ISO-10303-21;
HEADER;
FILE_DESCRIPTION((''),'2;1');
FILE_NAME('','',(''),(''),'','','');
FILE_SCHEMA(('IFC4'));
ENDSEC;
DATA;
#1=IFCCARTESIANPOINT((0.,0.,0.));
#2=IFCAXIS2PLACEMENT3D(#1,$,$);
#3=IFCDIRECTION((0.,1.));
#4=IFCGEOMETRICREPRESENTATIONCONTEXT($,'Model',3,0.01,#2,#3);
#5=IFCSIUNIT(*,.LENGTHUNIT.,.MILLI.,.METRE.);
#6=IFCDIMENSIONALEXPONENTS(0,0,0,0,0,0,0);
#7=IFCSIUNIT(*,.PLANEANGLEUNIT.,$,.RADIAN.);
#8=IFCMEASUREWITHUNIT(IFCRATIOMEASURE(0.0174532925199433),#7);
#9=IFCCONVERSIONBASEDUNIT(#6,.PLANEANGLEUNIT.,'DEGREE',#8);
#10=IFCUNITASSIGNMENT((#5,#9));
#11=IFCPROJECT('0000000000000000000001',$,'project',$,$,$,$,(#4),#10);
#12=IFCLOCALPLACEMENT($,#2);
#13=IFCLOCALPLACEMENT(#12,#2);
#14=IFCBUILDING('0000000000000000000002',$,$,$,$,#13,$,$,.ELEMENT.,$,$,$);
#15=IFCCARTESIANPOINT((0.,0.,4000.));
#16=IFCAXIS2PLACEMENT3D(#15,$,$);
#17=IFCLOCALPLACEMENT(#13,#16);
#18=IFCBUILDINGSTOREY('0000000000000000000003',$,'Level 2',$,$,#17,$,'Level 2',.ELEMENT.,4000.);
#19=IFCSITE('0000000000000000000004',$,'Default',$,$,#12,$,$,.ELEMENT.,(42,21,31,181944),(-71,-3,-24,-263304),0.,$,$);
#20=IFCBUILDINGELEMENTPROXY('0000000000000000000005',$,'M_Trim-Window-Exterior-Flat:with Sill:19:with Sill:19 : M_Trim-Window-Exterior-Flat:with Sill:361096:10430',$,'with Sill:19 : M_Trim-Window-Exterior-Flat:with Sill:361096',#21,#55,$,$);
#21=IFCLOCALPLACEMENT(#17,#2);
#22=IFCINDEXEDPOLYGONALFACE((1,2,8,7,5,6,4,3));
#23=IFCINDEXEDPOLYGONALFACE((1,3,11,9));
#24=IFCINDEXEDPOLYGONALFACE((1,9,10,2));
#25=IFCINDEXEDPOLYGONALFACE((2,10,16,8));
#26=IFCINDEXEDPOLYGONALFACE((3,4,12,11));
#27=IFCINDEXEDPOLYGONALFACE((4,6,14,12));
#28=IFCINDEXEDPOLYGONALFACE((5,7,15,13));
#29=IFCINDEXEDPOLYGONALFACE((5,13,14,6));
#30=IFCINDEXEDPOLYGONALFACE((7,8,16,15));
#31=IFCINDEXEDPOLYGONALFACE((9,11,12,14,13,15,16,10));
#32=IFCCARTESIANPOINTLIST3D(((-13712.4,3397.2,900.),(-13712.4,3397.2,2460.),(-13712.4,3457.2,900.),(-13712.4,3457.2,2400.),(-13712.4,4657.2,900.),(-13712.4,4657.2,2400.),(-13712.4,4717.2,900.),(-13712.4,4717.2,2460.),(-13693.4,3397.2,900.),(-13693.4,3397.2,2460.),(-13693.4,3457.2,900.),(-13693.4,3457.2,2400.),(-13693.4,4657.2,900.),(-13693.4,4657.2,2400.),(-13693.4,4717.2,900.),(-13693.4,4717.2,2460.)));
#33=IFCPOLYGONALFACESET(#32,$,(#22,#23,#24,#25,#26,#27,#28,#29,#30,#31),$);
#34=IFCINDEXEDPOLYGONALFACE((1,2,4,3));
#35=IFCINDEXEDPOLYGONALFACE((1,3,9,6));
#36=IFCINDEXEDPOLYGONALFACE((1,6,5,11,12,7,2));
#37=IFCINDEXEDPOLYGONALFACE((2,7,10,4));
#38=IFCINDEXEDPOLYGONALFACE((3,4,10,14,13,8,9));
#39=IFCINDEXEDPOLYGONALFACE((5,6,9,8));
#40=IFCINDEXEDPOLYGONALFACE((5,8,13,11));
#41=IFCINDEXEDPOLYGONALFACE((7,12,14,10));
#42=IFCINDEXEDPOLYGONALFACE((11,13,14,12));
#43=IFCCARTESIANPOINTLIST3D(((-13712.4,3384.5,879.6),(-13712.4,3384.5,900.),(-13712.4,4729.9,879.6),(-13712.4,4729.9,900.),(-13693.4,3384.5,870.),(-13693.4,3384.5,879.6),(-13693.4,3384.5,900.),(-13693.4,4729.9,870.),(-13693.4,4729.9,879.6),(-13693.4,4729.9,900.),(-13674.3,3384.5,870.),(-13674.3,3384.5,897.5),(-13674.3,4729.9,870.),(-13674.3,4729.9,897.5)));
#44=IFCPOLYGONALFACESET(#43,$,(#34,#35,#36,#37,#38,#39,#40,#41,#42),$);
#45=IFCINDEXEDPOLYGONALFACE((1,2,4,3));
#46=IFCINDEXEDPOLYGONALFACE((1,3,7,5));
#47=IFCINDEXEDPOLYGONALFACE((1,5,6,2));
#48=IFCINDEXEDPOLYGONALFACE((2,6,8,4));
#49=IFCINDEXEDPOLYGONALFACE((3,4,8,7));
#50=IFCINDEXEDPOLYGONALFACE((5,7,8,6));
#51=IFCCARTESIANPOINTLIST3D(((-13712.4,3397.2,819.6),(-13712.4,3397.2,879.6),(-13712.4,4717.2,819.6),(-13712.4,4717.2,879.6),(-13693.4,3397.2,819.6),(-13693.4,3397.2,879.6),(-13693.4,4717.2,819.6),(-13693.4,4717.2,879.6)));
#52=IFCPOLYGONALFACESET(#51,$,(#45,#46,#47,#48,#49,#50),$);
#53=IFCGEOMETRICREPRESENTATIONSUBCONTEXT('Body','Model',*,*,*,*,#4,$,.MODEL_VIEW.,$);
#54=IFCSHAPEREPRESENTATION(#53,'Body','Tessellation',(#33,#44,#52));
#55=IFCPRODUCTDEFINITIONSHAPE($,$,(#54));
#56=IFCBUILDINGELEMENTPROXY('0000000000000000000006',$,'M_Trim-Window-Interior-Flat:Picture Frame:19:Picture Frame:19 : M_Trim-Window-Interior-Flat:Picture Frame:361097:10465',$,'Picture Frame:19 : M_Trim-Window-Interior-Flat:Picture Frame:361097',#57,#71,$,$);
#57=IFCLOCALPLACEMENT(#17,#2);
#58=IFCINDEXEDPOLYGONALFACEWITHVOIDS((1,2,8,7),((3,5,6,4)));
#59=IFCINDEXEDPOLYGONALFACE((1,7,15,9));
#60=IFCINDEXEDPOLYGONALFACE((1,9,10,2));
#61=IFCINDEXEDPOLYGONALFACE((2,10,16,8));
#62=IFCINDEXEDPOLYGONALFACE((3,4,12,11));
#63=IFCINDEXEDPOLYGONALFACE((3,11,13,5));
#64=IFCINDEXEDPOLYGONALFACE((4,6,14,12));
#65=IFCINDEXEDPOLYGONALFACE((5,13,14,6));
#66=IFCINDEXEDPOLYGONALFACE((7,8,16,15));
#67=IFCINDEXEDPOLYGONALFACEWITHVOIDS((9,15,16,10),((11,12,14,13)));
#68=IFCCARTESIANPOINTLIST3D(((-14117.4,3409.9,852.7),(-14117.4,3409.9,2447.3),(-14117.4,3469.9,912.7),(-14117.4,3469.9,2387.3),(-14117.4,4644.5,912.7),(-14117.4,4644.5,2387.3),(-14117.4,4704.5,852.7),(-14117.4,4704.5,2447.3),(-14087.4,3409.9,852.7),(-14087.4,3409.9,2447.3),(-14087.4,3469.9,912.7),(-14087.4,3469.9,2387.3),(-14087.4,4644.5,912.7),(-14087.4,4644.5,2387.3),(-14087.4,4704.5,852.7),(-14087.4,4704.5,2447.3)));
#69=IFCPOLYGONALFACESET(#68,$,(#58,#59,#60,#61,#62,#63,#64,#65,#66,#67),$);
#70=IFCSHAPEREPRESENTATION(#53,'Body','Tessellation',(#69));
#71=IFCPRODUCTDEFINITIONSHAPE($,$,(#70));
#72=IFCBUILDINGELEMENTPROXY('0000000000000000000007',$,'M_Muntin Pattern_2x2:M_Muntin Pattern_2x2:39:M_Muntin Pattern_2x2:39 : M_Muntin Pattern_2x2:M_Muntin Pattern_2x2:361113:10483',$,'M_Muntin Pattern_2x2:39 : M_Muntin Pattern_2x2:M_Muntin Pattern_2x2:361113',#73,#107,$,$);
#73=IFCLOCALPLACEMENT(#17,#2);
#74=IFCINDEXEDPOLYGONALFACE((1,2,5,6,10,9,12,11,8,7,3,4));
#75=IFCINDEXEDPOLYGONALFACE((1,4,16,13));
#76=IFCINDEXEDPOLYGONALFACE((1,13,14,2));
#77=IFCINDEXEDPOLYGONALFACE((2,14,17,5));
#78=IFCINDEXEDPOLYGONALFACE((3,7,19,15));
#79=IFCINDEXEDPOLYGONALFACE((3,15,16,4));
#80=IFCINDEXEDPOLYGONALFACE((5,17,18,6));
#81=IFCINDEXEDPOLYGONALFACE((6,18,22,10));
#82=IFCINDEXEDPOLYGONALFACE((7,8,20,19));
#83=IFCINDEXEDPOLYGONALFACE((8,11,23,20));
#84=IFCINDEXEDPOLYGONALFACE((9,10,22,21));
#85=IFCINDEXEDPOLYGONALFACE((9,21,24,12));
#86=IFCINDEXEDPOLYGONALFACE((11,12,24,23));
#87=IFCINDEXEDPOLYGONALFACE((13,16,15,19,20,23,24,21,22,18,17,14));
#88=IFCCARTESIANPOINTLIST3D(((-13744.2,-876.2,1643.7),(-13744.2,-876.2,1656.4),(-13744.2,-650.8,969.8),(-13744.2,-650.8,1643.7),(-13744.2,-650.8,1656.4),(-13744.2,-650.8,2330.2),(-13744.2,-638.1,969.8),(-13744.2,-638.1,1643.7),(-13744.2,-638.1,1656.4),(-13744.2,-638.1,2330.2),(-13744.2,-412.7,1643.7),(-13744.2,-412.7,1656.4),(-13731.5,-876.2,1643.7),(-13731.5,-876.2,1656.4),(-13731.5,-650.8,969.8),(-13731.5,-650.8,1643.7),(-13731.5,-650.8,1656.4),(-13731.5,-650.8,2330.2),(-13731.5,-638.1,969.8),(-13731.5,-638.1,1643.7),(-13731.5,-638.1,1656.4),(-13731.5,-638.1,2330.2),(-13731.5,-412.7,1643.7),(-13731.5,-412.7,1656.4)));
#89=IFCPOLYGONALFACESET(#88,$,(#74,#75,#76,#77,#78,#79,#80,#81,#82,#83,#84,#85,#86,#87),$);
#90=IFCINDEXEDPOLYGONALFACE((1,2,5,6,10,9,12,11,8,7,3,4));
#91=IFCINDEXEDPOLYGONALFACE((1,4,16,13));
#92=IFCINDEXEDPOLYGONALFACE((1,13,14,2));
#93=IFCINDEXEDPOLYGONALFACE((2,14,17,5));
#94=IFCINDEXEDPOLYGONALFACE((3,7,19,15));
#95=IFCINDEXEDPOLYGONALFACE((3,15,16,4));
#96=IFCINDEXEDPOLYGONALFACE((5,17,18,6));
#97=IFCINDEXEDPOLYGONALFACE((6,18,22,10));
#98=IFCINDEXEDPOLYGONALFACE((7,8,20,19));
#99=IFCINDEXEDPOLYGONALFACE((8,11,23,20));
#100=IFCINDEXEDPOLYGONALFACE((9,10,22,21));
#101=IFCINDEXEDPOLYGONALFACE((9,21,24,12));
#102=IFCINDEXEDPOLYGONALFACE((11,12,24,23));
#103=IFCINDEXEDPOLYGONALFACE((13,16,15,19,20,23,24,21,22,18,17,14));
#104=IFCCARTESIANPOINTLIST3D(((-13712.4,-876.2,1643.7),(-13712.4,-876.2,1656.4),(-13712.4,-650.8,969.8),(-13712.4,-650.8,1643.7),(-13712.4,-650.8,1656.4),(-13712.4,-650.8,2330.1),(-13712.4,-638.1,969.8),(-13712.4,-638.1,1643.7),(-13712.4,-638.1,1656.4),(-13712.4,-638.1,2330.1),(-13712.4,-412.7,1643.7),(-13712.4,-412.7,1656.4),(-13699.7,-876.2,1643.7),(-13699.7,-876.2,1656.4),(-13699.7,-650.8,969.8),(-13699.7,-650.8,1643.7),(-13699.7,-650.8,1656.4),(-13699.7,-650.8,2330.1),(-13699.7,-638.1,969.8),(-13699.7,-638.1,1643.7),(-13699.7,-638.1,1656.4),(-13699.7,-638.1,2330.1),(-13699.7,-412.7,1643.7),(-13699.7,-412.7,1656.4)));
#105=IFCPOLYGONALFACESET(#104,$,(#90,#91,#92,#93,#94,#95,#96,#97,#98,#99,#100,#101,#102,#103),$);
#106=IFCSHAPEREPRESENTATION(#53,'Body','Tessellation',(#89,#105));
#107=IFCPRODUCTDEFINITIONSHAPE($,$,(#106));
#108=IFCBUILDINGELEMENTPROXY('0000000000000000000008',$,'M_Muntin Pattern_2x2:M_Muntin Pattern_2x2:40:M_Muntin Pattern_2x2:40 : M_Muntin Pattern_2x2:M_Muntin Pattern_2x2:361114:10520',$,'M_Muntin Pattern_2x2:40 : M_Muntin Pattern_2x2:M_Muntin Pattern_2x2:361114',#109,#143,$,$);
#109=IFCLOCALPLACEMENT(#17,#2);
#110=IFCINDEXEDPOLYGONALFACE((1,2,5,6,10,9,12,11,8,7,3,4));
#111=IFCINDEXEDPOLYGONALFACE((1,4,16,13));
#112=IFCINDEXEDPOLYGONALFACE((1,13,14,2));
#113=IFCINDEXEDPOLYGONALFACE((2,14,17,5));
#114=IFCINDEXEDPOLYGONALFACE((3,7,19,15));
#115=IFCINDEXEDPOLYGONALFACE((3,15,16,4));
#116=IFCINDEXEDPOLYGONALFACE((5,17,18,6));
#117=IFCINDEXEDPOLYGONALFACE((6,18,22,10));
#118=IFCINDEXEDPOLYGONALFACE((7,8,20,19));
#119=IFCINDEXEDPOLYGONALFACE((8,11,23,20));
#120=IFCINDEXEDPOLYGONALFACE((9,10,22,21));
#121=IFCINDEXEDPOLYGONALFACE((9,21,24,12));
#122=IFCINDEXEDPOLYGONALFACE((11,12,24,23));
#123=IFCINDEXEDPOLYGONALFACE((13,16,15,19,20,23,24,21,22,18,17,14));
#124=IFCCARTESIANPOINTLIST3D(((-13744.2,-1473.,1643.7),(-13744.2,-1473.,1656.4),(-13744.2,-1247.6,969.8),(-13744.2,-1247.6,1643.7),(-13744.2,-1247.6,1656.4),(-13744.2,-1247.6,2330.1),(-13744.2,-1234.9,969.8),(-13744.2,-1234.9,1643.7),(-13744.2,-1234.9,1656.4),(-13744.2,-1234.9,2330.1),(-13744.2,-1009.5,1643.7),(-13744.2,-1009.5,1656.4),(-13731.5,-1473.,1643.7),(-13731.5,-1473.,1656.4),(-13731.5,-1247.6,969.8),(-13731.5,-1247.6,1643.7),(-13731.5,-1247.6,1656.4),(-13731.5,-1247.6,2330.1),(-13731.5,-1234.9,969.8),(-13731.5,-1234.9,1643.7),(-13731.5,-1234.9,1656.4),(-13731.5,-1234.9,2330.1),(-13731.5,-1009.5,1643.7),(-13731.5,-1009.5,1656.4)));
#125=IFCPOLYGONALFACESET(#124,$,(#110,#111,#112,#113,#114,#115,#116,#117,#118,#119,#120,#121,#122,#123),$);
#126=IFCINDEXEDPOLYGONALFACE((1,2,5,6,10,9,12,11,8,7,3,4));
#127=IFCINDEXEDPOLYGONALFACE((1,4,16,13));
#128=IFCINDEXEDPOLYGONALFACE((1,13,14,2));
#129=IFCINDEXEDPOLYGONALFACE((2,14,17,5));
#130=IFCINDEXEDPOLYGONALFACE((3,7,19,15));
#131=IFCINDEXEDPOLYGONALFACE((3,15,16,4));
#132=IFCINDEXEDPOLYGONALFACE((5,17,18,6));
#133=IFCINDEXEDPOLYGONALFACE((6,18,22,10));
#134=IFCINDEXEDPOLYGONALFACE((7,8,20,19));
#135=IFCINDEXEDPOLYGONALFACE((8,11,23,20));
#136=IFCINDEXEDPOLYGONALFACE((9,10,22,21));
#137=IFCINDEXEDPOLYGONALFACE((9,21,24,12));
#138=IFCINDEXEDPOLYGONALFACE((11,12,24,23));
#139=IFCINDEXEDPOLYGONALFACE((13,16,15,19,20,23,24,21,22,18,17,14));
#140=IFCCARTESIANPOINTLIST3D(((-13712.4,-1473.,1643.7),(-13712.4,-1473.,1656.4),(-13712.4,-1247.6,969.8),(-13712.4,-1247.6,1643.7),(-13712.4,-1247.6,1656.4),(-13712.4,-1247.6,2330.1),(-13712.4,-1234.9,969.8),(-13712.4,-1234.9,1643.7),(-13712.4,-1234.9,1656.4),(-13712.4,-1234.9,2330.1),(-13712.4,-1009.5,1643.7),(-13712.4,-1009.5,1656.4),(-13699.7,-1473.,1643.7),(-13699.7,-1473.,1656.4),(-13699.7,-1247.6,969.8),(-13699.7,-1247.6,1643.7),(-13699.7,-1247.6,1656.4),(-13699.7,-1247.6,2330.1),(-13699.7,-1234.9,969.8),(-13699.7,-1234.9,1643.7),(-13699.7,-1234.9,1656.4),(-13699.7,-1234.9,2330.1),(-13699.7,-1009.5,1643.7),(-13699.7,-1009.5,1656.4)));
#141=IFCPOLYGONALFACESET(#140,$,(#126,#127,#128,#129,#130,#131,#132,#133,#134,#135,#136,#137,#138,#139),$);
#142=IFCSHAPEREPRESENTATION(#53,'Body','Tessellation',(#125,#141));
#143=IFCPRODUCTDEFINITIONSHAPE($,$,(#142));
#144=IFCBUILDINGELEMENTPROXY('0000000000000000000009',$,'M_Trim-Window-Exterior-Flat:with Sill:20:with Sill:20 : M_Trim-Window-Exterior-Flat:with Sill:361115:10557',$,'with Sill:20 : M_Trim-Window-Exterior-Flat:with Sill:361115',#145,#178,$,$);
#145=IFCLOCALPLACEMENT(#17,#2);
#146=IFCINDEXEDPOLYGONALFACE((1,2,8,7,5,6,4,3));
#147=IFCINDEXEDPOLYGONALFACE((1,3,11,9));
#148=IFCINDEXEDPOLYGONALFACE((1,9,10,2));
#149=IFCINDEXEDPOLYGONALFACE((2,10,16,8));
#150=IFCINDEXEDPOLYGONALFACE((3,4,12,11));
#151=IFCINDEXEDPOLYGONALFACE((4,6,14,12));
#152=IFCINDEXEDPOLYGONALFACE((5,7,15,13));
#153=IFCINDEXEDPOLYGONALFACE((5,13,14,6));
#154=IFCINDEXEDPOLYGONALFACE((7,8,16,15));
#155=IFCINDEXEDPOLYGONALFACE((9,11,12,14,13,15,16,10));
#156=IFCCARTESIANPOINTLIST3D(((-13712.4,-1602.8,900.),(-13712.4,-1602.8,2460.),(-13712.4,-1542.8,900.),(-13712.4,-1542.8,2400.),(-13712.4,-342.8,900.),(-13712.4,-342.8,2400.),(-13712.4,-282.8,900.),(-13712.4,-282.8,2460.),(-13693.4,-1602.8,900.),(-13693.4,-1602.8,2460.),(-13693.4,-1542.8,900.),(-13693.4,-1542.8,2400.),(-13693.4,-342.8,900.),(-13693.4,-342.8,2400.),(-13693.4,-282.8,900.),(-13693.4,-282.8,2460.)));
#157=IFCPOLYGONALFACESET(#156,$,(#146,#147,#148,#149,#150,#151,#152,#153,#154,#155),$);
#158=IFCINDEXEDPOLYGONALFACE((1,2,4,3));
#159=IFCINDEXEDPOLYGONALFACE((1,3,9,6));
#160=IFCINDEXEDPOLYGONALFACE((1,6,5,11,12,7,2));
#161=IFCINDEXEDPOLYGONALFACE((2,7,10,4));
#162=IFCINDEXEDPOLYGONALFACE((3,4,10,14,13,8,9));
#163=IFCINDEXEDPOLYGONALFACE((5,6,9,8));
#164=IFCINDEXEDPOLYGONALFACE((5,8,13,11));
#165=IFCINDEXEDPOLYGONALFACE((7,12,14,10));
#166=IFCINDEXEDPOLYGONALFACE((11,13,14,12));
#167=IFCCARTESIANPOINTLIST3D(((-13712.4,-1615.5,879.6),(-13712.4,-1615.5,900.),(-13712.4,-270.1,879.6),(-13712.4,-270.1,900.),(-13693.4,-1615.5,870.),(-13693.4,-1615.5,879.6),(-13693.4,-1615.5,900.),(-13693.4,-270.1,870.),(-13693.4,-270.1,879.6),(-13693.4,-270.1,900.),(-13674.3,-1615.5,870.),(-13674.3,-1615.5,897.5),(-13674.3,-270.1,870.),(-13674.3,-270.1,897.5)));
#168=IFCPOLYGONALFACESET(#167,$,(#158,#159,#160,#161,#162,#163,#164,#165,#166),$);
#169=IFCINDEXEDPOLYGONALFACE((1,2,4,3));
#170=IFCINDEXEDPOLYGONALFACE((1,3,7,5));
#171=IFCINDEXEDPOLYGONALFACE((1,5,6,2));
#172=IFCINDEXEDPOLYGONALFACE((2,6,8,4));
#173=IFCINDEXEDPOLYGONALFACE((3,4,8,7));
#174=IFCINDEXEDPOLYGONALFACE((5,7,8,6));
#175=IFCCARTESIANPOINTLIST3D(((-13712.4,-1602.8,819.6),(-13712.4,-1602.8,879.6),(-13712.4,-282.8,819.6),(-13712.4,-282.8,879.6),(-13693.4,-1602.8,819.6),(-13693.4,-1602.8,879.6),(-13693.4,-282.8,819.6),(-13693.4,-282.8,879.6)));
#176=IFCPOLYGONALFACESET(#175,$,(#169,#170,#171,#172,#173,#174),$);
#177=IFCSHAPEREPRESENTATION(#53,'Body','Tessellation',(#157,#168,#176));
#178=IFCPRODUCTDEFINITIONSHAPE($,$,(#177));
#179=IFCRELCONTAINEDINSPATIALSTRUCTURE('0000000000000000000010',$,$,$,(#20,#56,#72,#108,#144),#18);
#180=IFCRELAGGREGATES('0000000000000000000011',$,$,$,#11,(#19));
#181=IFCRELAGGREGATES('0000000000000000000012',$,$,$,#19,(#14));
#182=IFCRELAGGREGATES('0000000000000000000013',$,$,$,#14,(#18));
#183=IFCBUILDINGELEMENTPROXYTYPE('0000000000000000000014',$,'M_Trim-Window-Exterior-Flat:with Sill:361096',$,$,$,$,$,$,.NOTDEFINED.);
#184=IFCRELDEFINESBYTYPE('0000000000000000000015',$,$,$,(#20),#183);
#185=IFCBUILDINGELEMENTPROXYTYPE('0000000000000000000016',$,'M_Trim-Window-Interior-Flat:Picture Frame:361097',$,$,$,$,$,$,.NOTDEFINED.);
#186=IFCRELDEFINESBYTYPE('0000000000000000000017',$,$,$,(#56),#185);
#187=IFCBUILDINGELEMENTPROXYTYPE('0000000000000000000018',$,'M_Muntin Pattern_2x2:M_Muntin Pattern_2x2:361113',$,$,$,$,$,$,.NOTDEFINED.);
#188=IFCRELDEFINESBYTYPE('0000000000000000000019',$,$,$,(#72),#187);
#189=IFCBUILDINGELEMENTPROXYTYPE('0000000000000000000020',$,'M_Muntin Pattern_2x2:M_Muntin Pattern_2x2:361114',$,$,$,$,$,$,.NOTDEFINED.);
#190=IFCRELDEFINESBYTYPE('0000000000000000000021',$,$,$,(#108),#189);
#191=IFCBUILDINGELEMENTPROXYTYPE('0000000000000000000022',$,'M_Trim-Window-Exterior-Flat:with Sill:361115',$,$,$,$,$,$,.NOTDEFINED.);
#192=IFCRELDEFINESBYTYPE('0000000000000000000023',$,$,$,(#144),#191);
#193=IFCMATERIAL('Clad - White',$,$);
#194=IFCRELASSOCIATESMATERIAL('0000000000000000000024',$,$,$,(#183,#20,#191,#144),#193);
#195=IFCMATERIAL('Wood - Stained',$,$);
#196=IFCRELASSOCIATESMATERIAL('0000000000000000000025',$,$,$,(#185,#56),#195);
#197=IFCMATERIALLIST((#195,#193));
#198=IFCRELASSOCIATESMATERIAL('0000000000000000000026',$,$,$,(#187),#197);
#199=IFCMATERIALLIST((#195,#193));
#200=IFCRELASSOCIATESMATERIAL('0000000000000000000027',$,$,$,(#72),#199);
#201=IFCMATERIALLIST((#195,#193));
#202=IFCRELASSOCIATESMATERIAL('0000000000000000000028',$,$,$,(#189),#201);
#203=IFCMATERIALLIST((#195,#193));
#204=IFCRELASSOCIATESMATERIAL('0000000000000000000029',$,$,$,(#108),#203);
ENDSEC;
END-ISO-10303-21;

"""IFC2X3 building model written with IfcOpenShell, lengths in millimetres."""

from ifc_helpers import new_model, entity, si_unit, converted_unit, direction, frame, frame_2d, origin, origin_2d_with_axis, place, context, subcontext, project, spatial, polyline, rectangle, outline, extrude, source, transform, mapped, material, material_list, type_object, type_shapes, element, save


model = new_model("IFC2X3")

# Units and contexts
model_context = context("Model", 3, precision=0.01, world=origin(), true_north=direction((0.0, 1.0)))
body_context = subcontext(model_context, "Body", "Model", "MODEL_VIEW")
ifc_project = project(units=[si_unit("LENGTHUNIT", "METRE", prefix="MILLI"), converted_unit("PLANEANGLEUNIT", "DEGREE", entity("IfcRatioMeasure", 0.0174532925199433), si_unit("PLANEANGLEUNIT", "RADIAN"), dimensions=[0, 0, 0, 0, 0, 0, 0])], contexts=[model_context])

# Site, building, storey
site_placement = place(None, origin())
site = spatial("IfcSite", under=ifc_project, at=site_placement, Name="Default", CompositionType="ELEMENT", RefLatitude=(42, 21, 31, 181944), RefLongitude=(-71, -3, -24, -263304), RefElevation=0.0)
building_placement = place(site_placement, origin())
building = spatial("IfcBuilding", under=site, at=building_placement, CompositionType="ELEMENT")
storey_placement = place(building_placement, frame((0.0, 0.0, 4000.0)))
storey = spatial("IfcBuildingStorey", under=building, at=storey_placement, Name="Level 2", LongName="Level 2", CompositionType="ELEMENT", Elevation=4000.0)

# Building element proxies
ifc_material_1 = material(Name="Wood - Stained")
ifc_material_2 = material(Name="Clad - White")
building_element_proxy_type_1 = type_object("IfcBuildingElementProxyType", Name="M_Trim-Window-Exterior-Flat:with Sill:361096", PredefinedType="NOTDEFINED", material=ifc_material_2)
shared_shape_1 = source(origin(), body_context, "Body", "SweptSolid", [
    extrude(outline(polyline([(-660.0, -765.0), (-600.0, -765.0), (-600.0, 735.0), (600.0, 735.0), (600.0, -765.0), (660.0, -765.0), (660.0, 795.0), (-660.0, 795.0), (-660.0, -765.0)])), frame((-13712.4, 4057.2, 5665.0), z_axis=(1.0, 0.0, 0.0), x_axis=(0.0, 1.0, 0.0)), (0.0, 0.0, 1.0), 19.1),
    extrude(outline(polyline([(-15.2, 0.0), (-15.2, -19.0), (12.3, -19.0), (14.8, 0.0), (14.8, 19.0), (-5.7, 19.0), (-5.7, 0.0), (-15.2, 0.0)])), frame((-13693.4, 3384.5, 4885.2), z_axis=(0.0, -1.0, 0.0), x_axis=(0.0, 0.0, 1.0)), (0.0, 0.0, -1.0), 1345.4),
    extrude(rectangle(XDim=19.1, YDim=1320.0, at=frame_2d((0.0, 0.0), x_axis=(1.0, 0.0))), frame((-13702.9, 4057.2, 4819.6), z_axis=(0.0, 0.0, 1.0), x_axis=(-1.0, 0.0, 0.0)), (0.0, 0.0, 1.0), 60.0),
])
type_shapes(building_element_proxy_type_1, [shared_shape_1])
proxy_1_placement = place(storey_placement, frame((0.0, 0.0, -4000.0)))
element("IfcBuildingElementProxy", 1, at=proxy_1_placement, inside=storey, type_object=building_element_proxy_type_1, material=ifc_material_2, Name="M_Trim-Window-Exterior-Flat:with Sill:19:with Sill:19 : M_Trim-Window-Exterior-Flat:with Sill:361096:10430", ObjectType="with Sill:19 : M_Trim-Window-Exterior-Flat:with Sill:361096", context=body_context, shape_type="MappedRepresentation", body=[
    mapped(shared_shape_1, transform((0.0, 0.0, 0.0), scale=1.0)),
])
building_element_proxy_type_2 = type_object("IfcBuildingElementProxyType", Name="M_Trim-Window-Interior-Flat:Picture Frame:361097", PredefinedType="NOTDEFINED", material=ifc_material_1)
shared_shape_2 = source(origin(), body_context, "Body", "SweptSolid", [
    extrude(outline(polyline([(-647.3, -797.3), (647.3, -797.3), (647.3, 797.3), (-647.3, 797.3), (-647.3, -797.3)]), holes=[polyline([(587.3, 737.3), (587.3, -737.3), (-587.3, -737.3), (-587.3, 737.3), (587.3, 737.3)])]), frame((-14117.4, 4057.2, 5650.0), z_axis=(1.0, 0.0, 0.0), x_axis=(0.0, -1.0, 0.0)), (0.0, 0.0, 1.0), 30.0),
])
type_shapes(building_element_proxy_type_2, [shared_shape_2])
proxy_2_placement = place(storey_placement, frame((0.0, 0.0, -4000.0)))
element("IfcBuildingElementProxy", 2, at=proxy_2_placement, inside=storey, type_object=building_element_proxy_type_2, material=ifc_material_1, Name="M_Trim-Window-Interior-Flat:Picture Frame:19:Picture Frame:19 : M_Trim-Window-Interior-Flat:Picture Frame:361097:10465", ObjectType="Picture Frame:19 : M_Trim-Window-Interior-Flat:Picture Frame:361097", context=body_context, shape_type="MappedRepresentation", body=[
    mapped(shared_shape_2, transform((0.0, 0.0, 0.0), scale=1.0)),
])
ifc_material_list_1 = material_list([ifc_material_1, ifc_material_2])
ifc_material_list_2 = material_list([ifc_material_1, ifc_material_2])
building_element_proxy_type_3 = type_object("IfcBuildingElementProxyType", Name="M_Muntin Pattern_2x2:M_Muntin Pattern_2x2:361113", PredefinedType="NOTDEFINED", material=ifc_material_list_2)
shared_shape_3 = source(origin(), body_context, "Body", "SweptSolid", [
    extrude(outline(polyline([(-6.4, -680.2), (6.3, -680.2), (6.3, -6.4), (231.7, -6.4), (231.7, 6.3), (6.3, 6.3), (6.3, 680.2), (-6.4, 680.2), (-6.4, 6.3), (-231.7, 6.3), (-231.7, -6.4), (-6.4, -6.4), (-6.4, -680.2)])), frame((-13744.2, -644.4, 5650.0), z_axis=(1.0, 0.0, 0.0), x_axis=(0.0, -1.0, 0.0)), (0.0, 0.0, 1.0), 12.7),
    extrude(outline(polyline([(-6.4, -680.1), (6.3, -680.1), (6.3, -6.4), (231.7, -6.4), (231.7, 6.3), (6.3, 6.3), (6.3, 680.2), (-6.4, 680.2), (-6.4, 6.3), (-231.7, 6.3), (-231.7, -6.4), (-6.4, -6.4), (-6.4, -680.1)])), frame((-13712.4, -644.4, 5650.0), z_axis=(1.0, 0.0, 0.0), x_axis=(0.0, -1.0, 0.0)), (0.0, 0.0, 1.0), 12.7),
])
type_shapes(building_element_proxy_type_3, [shared_shape_3])
proxy_3_placement = place(storey_placement, frame((0.0, 0.0, -4000.0)))
element("IfcBuildingElementProxy", 3, at=proxy_3_placement, inside=storey, type_object=building_element_proxy_type_3, material=ifc_material_list_1, Name="M_Muntin Pattern_2x2:M_Muntin Pattern_2x2:39:M_Muntin Pattern_2x2:39 : M_Muntin Pattern_2x2:M_Muntin Pattern_2x2:361113:10483", ObjectType="M_Muntin Pattern_2x2:39 : M_Muntin Pattern_2x2:M_Muntin Pattern_2x2:361113", context=body_context, shape_type="MappedRepresentation", body=[
    mapped(shared_shape_3, transform((0.0, 0.0, 0.0), scale=1.0)),
])
ifc_material_list_3 = material_list([ifc_material_1, ifc_material_2])
ifc_material_list_4 = material_list([ifc_material_1, ifc_material_2])
building_element_proxy_type_4 = type_object("IfcBuildingElementProxyType", Name="M_Muntin Pattern_2x2:M_Muntin Pattern_2x2:361114", PredefinedType="NOTDEFINED", material=ifc_material_list_4)
shared_shape_4 = source(origin(), body_context, "Body", "SweptSolid", [
    extrude(outline(polyline([(-680.1, 6.4), (-680.1, -6.3), (-6.4, -6.3), (-6.4, -231.7), (6.3, -231.7), (6.3, -6.3), (680.2, -6.3), (680.2, 6.4), (6.3, 6.4), (6.3, 231.7), (-6.4, 231.7), (-6.4, 6.4), (-680.1, 6.4)])), frame((-13744.2, -1241.3, 5650.0), z_axis=(-1.0, 0.0, 0.0), x_axis=(0.0, 0.0, -1.0)), (0.0, 0.0, -1.0), 12.7),
    extrude(outline(polyline([(-680.1, 6.4), (-680.1, -6.3), (-6.4, -6.3), (-6.4, -231.7), (6.3, -231.7), (6.3, -6.3), (680.2, -6.3), (680.2, 6.4), (6.3, 6.4), (6.3, 231.7), (-6.4, 231.7), (-6.4, 6.4), (-680.1, 6.4)])), frame((-13712.4, -1241.3, 5650.0), z_axis=(-1.0, 0.0, 0.0), x_axis=(0.0, 0.0, -1.0)), (0.0, 0.0, -1.0), 12.7),
])
type_shapes(building_element_proxy_type_4, [shared_shape_4])
proxy_4_placement = place(storey_placement, frame((0.0, 0.0, -4000.0)))
element("IfcBuildingElementProxy", 4, at=proxy_4_placement, inside=storey, type_object=building_element_proxy_type_4, material=ifc_material_list_3, Name="M_Muntin Pattern_2x2:M_Muntin Pattern_2x2:40:M_Muntin Pattern_2x2:40 : M_Muntin Pattern_2x2:M_Muntin Pattern_2x2:361114:10520", ObjectType="M_Muntin Pattern_2x2:40 : M_Muntin Pattern_2x2:M_Muntin Pattern_2x2:361114", context=body_context, shape_type="MappedRepresentation", body=[
    mapped(shared_shape_4, transform((0.0, 0.0, 0.0), scale=1.0)),
])
building_element_proxy_type_5 = type_object("IfcBuildingElementProxyType", Name="M_Trim-Window-Exterior-Flat:with Sill:361115", PredefinedType="NOTDEFINED", material=ifc_material_2)
shared_shape_5 = source(origin(), body_context, "Body", "SweptSolid", [
    extrude(outline(polyline([(-660.0, -765.0), (-600.0, -765.0), (-600.0, 735.0), (600.0, 735.0), (600.0, -765.0), (660.0, -765.0), (660.0, 795.0), (-660.0, 795.0), (-660.0, -765.0)])), frame((-13712.4, -942.8, 5665.0), z_axis=(1.0, 0.0, 0.0), x_axis=(0.0, 1.0, 0.0)), (0.0, 0.0, 1.0), 19.1),
    extrude(outline(polyline([(-15.2, 0.0), (-15.2, -19.0), (12.3, -19.0), (14.8, 0.0), (14.8, 19.0), (-5.7, 19.0), (-5.7, 0.0), (-15.2, 0.0)])), frame((-13693.4, -1615.5, 4885.2), z_axis=(0.0, -1.0, 0.0), x_axis=(0.0, 0.0, 1.0)), (0.0, 0.0, -1.0), 1345.4),
    extrude(rectangle(XDim=19.1, YDim=1320.0, at=origin_2d_with_axis()), frame((-13702.9, -942.8, 4819.6), z_axis=(0.0, 0.0, 1.0), x_axis=(-1.0, 0.0, 0.0)), (0.0, 0.0, 1.0), 60.0),
])
type_shapes(building_element_proxy_type_5, [shared_shape_5])
proxy_5_placement = place(storey_placement, frame((0.0, 0.0, -4000.0)))
element("IfcBuildingElementProxy", 5, at=proxy_5_placement, inside=storey, type_object=building_element_proxy_type_5, material=ifc_material_2, Name="M_Trim-Window-Exterior-Flat:with Sill:20:with Sill:20 : M_Trim-Window-Exterior-Flat:with Sill:361115:10557", ObjectType="with Sill:20 : M_Trim-Window-Exterior-Flat:with Sill:361115", context=body_context, shape_type="MappedRepresentation", body=[
    mapped(shared_shape_5, transform((0.0, 0.0, 0.0), scale=1.0)),
])

save(model, "model.ifc")
